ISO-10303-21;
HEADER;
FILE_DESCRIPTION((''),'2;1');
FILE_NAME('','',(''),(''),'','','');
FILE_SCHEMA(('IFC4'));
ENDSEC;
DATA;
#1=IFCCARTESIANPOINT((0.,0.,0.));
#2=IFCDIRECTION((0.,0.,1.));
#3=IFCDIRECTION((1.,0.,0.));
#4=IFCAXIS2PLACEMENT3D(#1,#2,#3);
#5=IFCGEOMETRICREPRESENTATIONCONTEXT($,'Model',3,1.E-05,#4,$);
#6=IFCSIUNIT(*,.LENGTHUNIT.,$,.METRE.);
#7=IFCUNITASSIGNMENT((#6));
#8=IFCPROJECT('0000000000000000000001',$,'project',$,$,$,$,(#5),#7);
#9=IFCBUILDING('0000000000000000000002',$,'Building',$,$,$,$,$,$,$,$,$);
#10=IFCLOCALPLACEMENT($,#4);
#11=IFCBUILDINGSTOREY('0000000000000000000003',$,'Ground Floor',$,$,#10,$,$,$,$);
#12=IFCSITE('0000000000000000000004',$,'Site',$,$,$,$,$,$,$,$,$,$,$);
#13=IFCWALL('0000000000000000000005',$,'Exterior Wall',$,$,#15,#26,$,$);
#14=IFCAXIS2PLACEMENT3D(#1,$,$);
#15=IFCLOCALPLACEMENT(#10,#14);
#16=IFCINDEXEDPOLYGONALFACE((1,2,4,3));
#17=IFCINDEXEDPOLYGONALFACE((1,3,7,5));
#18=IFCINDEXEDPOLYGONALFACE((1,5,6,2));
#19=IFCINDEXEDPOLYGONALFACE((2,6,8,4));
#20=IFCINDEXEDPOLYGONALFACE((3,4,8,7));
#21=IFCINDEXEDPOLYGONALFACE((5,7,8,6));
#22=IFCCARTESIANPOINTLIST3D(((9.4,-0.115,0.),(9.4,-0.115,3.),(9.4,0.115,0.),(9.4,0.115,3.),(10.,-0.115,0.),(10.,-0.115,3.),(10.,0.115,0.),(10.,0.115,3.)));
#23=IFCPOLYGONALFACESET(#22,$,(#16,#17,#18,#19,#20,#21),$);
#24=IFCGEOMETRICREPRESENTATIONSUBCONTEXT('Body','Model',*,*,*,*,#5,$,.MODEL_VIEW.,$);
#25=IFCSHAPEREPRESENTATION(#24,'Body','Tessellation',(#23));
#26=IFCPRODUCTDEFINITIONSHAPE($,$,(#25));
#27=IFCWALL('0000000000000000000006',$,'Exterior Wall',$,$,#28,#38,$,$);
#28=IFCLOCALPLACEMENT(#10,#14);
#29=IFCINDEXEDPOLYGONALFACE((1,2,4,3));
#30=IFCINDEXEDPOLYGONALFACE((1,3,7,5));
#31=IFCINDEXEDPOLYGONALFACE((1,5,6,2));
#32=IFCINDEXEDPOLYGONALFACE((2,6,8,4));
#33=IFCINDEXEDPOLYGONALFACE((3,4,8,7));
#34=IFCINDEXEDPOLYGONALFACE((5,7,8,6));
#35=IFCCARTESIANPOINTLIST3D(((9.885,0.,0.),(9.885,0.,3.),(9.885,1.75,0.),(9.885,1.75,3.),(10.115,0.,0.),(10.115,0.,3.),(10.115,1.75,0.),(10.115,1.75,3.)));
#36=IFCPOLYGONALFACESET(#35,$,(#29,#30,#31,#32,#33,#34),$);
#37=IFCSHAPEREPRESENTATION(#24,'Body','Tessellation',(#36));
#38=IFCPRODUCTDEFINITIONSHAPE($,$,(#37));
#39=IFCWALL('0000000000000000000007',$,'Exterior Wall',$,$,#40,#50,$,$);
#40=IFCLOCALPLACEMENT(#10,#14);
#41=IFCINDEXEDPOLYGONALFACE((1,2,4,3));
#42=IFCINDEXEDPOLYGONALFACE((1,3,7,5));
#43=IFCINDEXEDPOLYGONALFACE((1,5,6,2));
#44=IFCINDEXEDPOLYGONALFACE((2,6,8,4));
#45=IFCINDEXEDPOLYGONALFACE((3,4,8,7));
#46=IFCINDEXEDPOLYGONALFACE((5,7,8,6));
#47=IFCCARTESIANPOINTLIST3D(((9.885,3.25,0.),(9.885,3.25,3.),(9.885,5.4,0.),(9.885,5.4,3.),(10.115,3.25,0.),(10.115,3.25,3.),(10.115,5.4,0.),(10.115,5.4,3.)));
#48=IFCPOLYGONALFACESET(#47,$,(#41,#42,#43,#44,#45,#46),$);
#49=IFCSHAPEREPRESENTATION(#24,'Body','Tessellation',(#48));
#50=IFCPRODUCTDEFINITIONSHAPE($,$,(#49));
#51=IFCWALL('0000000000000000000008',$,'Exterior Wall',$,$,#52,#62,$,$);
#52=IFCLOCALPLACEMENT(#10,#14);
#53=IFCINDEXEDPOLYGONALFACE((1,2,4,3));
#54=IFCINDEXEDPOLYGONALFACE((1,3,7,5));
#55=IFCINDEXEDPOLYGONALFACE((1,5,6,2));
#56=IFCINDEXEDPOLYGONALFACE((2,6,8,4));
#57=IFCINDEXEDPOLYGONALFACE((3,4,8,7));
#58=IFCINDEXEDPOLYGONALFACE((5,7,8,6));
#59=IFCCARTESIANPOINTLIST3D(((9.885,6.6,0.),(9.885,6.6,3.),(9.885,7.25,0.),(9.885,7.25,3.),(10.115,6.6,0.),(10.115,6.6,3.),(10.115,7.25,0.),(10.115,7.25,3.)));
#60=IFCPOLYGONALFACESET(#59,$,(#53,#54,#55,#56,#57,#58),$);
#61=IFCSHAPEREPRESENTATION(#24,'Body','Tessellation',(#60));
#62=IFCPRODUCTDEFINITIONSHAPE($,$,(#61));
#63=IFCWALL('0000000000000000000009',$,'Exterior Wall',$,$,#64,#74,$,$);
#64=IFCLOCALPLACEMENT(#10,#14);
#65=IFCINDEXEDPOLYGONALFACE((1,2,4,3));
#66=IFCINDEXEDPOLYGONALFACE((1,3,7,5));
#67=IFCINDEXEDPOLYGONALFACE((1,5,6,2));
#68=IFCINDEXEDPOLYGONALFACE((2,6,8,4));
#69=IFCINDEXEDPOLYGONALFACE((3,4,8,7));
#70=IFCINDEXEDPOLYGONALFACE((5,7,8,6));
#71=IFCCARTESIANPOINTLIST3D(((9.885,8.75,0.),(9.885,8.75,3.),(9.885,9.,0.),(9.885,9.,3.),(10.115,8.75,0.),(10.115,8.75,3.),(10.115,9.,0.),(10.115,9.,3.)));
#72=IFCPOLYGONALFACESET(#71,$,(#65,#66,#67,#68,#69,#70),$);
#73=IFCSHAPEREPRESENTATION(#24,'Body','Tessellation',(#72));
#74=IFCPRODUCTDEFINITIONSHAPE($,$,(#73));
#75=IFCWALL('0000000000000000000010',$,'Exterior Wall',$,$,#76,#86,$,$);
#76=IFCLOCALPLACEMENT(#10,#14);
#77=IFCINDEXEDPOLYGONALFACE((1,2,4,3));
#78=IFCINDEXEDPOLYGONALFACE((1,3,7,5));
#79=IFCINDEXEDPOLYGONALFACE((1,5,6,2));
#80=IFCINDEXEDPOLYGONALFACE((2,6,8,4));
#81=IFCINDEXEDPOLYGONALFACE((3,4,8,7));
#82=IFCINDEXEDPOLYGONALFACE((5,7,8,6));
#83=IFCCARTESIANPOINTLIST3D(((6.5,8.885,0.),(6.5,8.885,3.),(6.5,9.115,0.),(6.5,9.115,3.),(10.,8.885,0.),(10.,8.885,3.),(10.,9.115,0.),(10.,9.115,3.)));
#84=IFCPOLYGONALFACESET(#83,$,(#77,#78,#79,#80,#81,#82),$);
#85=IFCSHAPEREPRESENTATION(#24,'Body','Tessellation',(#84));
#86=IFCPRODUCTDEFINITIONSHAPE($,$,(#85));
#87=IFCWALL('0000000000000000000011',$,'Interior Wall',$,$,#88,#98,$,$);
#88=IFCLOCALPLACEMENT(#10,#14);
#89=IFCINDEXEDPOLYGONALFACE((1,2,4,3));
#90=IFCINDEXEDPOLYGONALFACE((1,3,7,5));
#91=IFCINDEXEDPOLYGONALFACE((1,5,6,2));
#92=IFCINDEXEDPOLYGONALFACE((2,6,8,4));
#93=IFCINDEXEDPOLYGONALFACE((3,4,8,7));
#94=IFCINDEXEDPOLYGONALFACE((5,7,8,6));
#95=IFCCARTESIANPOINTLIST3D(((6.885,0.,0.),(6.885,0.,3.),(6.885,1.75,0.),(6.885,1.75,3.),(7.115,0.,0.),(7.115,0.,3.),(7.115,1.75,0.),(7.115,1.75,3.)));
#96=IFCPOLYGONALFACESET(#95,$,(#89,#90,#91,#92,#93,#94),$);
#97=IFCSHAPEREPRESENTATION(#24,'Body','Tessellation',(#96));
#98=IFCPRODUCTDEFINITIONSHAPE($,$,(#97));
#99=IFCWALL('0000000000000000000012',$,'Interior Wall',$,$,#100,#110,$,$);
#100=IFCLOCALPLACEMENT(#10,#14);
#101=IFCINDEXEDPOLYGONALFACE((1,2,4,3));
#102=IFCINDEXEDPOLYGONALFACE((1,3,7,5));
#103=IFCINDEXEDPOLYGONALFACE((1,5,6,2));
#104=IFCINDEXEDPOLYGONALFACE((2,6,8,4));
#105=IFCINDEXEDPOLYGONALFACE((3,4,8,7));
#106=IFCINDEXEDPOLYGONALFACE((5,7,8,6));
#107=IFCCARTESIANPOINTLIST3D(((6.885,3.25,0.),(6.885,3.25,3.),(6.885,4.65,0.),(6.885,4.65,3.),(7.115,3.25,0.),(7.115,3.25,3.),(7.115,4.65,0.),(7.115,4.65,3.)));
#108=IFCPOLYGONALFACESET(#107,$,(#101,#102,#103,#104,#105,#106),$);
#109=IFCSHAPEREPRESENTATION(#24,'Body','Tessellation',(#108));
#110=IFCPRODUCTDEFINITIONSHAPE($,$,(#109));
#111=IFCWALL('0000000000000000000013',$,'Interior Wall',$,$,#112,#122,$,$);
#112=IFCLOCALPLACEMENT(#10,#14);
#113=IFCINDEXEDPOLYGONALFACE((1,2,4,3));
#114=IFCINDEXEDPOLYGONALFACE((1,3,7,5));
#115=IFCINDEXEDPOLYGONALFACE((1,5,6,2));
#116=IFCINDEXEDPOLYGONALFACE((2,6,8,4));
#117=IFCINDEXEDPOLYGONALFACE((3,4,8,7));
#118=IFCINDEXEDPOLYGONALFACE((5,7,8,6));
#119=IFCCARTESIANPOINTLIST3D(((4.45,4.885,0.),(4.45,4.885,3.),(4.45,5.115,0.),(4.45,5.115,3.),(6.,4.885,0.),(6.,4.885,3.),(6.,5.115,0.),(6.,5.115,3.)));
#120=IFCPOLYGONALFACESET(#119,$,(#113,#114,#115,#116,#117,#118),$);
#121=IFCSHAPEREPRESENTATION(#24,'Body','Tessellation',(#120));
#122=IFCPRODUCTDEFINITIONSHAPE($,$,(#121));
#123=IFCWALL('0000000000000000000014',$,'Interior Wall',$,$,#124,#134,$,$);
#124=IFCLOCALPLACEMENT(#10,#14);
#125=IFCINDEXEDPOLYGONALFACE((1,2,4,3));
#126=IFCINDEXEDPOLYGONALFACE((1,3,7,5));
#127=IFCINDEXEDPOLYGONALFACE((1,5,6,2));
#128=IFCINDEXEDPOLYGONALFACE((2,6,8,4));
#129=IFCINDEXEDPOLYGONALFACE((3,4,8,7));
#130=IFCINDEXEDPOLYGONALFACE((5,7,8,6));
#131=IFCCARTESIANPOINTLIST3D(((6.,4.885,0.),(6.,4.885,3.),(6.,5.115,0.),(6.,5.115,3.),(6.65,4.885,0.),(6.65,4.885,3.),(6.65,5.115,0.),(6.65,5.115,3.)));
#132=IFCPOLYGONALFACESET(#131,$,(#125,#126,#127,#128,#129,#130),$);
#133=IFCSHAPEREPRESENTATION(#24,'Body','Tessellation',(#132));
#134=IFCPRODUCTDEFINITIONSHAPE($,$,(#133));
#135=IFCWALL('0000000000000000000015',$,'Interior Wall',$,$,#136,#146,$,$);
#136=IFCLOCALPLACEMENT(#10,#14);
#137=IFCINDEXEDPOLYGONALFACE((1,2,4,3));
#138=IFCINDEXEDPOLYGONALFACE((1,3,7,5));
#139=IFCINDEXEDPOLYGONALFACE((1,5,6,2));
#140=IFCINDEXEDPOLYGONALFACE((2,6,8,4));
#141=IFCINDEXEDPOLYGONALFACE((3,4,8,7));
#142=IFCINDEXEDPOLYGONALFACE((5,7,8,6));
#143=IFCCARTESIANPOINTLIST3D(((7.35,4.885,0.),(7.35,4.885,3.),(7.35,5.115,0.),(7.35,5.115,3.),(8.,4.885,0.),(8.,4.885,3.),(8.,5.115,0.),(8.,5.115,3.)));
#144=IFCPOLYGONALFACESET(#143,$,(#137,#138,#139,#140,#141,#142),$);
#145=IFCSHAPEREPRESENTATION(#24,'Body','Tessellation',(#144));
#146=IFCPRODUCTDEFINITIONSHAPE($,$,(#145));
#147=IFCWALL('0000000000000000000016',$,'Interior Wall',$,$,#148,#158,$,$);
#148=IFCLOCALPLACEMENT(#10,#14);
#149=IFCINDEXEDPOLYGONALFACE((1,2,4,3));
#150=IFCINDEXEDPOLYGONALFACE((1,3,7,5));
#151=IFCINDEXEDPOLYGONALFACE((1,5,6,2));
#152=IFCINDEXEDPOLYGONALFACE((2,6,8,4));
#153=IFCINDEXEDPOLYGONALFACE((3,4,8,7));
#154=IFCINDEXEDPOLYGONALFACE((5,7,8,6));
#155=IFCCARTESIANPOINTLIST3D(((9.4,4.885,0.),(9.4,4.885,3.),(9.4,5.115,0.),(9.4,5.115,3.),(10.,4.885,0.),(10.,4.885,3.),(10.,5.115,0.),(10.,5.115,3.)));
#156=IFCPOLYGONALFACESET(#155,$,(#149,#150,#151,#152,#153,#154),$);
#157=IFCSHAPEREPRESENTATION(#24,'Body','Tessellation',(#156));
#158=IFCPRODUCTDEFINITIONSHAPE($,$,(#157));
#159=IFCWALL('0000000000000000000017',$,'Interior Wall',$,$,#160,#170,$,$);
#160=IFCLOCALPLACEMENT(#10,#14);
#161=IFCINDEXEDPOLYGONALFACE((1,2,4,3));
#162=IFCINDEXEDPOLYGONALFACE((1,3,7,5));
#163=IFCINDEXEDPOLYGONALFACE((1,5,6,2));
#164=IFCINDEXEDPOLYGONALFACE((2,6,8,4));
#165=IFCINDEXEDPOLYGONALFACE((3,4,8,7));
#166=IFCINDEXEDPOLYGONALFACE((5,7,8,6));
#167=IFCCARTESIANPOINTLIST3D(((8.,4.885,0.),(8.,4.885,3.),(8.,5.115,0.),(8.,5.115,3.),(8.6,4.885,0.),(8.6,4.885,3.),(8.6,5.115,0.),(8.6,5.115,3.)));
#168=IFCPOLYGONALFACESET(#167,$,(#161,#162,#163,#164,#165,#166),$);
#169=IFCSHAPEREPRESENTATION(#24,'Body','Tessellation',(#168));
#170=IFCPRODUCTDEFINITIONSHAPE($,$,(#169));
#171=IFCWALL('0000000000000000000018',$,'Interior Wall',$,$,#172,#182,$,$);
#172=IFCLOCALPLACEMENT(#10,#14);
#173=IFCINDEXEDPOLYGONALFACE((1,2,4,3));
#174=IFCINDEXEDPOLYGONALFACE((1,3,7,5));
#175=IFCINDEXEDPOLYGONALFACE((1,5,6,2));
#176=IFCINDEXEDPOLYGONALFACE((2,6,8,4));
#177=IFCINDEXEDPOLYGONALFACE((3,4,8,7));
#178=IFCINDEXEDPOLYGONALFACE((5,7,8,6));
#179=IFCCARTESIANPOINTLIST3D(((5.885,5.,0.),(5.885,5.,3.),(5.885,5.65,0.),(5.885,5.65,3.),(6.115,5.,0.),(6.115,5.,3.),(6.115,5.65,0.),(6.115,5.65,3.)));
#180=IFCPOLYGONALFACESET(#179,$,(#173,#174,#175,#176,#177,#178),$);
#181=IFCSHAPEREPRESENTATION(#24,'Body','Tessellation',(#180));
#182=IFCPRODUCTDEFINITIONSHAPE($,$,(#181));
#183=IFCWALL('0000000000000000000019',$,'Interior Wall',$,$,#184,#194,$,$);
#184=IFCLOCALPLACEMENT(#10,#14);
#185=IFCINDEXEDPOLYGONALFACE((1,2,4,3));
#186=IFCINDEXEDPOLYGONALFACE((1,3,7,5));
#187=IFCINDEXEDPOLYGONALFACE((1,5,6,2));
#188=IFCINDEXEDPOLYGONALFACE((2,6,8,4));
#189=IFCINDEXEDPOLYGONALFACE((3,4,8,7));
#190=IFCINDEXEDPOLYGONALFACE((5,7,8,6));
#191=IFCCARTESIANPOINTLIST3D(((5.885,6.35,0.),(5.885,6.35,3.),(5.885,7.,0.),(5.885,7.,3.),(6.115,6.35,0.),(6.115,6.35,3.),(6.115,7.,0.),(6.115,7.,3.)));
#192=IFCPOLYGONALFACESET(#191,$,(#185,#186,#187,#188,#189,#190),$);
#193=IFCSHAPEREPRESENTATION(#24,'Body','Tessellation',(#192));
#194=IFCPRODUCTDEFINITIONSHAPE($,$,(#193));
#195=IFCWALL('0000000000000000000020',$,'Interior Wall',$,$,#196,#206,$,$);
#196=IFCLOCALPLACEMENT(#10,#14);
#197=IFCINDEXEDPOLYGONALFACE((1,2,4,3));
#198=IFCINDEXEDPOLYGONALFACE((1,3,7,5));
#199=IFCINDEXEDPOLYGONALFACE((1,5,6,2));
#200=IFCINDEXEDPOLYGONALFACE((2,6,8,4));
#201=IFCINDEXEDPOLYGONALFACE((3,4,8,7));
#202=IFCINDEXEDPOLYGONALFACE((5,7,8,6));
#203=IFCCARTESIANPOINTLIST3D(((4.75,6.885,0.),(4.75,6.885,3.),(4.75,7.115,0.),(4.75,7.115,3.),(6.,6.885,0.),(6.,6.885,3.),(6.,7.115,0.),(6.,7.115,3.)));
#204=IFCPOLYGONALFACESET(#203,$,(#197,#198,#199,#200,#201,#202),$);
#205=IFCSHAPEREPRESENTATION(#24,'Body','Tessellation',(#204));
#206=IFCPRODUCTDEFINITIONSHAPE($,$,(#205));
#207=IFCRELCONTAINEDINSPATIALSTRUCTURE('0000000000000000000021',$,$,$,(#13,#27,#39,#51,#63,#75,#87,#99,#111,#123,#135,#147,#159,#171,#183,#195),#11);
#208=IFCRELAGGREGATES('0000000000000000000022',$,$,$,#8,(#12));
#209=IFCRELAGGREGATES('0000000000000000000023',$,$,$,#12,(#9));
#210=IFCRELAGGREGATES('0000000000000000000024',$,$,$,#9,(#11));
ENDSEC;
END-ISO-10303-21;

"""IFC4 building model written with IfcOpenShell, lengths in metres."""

from ifc_helpers import new_model, si_unit, frame, origin_with_axes, place, context, subcontext, project, spatial, indexed_curve, outline, extrude, element, save


model = new_model("IFC4")

# Units and contexts
model_context = context("Model", 3, precision=1e-05, world=origin_with_axes())
body_context = subcontext(model_context, "Body", "Model", "MODEL_VIEW")
ifc_project = project(units=[si_unit("LENGTHUNIT", "METRE")], contexts=[model_context])

# Site, building, storey
site = spatial("IfcSite", under=ifc_project, Name="Site")
building = spatial("IfcBuilding", under=site, Name="Building")
storey_placement = place(None, origin_with_axes())
storey = spatial("IfcBuildingStorey", under=building, at=storey_placement, Name="Ground Floor")

# Walls
wall_1_placement = place(storey_placement, frame((9.4, 0.0, 0.0), z_axis=(0.0, 0.0, 1.0), x_axis=(1.0, 0.0, 0.0)))
element("IfcWall", 1, at=wall_1_placement, inside=storey, Name="Exterior Wall", context=body_context, shape_type="SweptSolid", body=[
    extrude(outline(indexed_curve([(0.0, 0.0), (0.0, 0.23), (0.6, 0.23), (0.6, 0.0), (0.0, 0.0)], self_intersect=False)), frame((0.0, -0.115, 0.0), z_axis=(0.0, 0.0, 1.0), x_axis=(1.0, 0.0, 0.0)), (0.0, 0.0, 1.0), 3.0),
])
wall_2_placement = place(storey_placement, frame((10.0, 0.0, 0.0), z_axis=(0.0, 0.0, 1.0), x_axis=(0.0, 1.0, 0.0)))
element("IfcWall", 2, at=wall_2_placement, inside=storey, Name="Exterior Wall", context=body_context, shape_type="SweptSolid", body=[
    extrude(outline(indexed_curve([(0.0, 0.0), (0.0, 0.23), (1.75, 0.23), (1.75, 0.0), (0.0, 0.0)], self_intersect=False)), frame((0.0, -0.115, 0.0), z_axis=(0.0, 0.0, 1.0), x_axis=(1.0, 0.0, 0.0)), (0.0, 0.0, 1.0), 3.0),
])
wall_3_placement = place(storey_placement, frame((10.0, 3.25, 0.0), z_axis=(0.0, 0.0, 1.0), x_axis=(0.0, 1.0, 0.0)))
element("IfcWall", 3, at=wall_3_placement, inside=storey, Name="Exterior Wall", context=body_context, shape_type="SweptSolid", body=[
    extrude(outline(indexed_curve([(0.0, 0.0), (0.0, 0.23), (2.15, 0.23), (2.15, 0.0), (0.0, 0.0)], self_intersect=False)), frame((0.0, -0.115, 0.0), z_axis=(0.0, 0.0, 1.0), x_axis=(1.0, 0.0, 0.0)), (0.0, 0.0, 1.0), 3.0),
])
wall_4_placement = place(storey_placement, frame((10.0, 6.6, 0.0), z_axis=(0.0, 0.0, 1.0), x_axis=(0.0, 1.0, 0.0)))
element("IfcWall", 4, at=wall_4_placement, inside=storey, Name="Exterior Wall", context=body_context, shape_type="SweptSolid", body=[
    extrude(outline(indexed_curve([(0.0, 0.0), (0.0, 0.23), (0.65, 0.23), (0.65, 0.0), (0.0, 0.0)], self_intersect=False)), frame((0.0, -0.115, 0.0), z_axis=(0.0, 0.0, 1.0), x_axis=(1.0, 0.0, 0.0)), (0.0, 0.0, 1.0), 3.0),
])
wall_5_placement = place(storey_placement, frame((10.0, 8.75, 0.0), z_axis=(0.0, 0.0, 1.0), x_axis=(0.0, 1.0, 0.0)))
element("IfcWall", 5, at=wall_5_placement, inside=storey, Name="Exterior Wall", context=body_context, shape_type="SweptSolid", body=[
    extrude(outline(indexed_curve([(0.0, 0.0), (0.0, 0.23), (0.25, 0.23), (0.25, 0.0), (0.0, 0.0)], self_intersect=False)), frame((0.0, -0.115, 0.0), z_axis=(0.0, 0.0, 1.0), x_axis=(1.0, 0.0, 0.0)), (0.0, 0.0, 1.0), 3.0),
])
wall_6_placement = place(storey_placement, frame((10.0, 9.0, 0.0), z_axis=(0.0, 0.0, 1.0), x_axis=(-1.0, 0.0, 0.0)))
element("IfcWall", 6, at=wall_6_placement, inside=storey, Name="Exterior Wall", context=body_context, shape_type="SweptSolid", body=[
    extrude(outline(indexed_curve([(0.0, 0.0), (0.0, 0.23), (3.5, 0.23), (3.5, 0.0), (0.0, 0.0)], self_intersect=False)), frame((0.0, -0.115, 0.0), z_axis=(0.0, 0.0, 1.0), x_axis=(1.0, 0.0, 0.0)), (0.0, 0.0, 1.0), 3.0),
])
wall_7_placement = place(storey_placement, frame((7.0, 0.0, 0.0), z_axis=(0.0, 0.0, 1.0), x_axis=(0.0, 1.0, 0.0)))
element("IfcWall", 7, at=wall_7_placement, inside=storey, Name="Interior Wall", context=body_context, shape_type="SweptSolid", body=[
    extrude(outline(indexed_curve([(0.0, 0.0), (0.0, 0.23), (1.75, 0.23), (1.75, 0.0), (0.0, 0.0)], self_intersect=False)), frame((0.0, -0.115, 0.0), z_axis=(0.0, 0.0, 1.0), x_axis=(1.0, 0.0, 0.0)), (0.0, 0.0, 1.0), 3.0),
])
wall_8_placement = place(storey_placement, frame((7.0, 3.25, 0.0), z_axis=(0.0, 0.0, 1.0), x_axis=(0.0, 1.0, 0.0)))
element("IfcWall", 8, at=wall_8_placement, inside=storey, Name="Interior Wall", context=body_context, shape_type="SweptSolid", body=[
    extrude(outline(indexed_curve([(0.0, 0.0), (0.0, 0.23), (1.4, 0.23), (1.4, 0.0), (0.0, 0.0)], self_intersect=False)), frame((0.0, -0.115, 0.0), z_axis=(0.0, 0.0, 1.0), x_axis=(1.0, 0.0, 0.0)), (0.0, 0.0, 1.0), 3.0),
])
wall_9_placement = place(storey_placement, frame((6.0, 5.0, 0.0), z_axis=(0.0, 0.0, 1.0), x_axis=(-1.0, 0.0, 0.0)))
element("IfcWall", 9, at=wall_9_placement, inside=storey, Name="Interior Wall", context=body_context, shape_type="SweptSolid", body=[
    extrude(outline(indexed_curve([(0.0, 0.0), (0.0, 0.23), (1.55, 0.23), (1.55, 0.0), (0.0, 0.0)], self_intersect=False)), frame((0.0, -0.115, 0.0), z_axis=(0.0, 0.0, 1.0), x_axis=(1.0, 0.0, 0.0)), (0.0, 0.0, 1.0), 3.0),
])
for number, where, z_axis, x_axis, name in (
    (10, (6.65, 5.0, 0.0), (0.0, 0.0, 1.0), (-1.0, 0.0, 0.0), "Interior Wall"),
    (11, (8.0, 5.0, 0.0), (0.0, 0.0, 1.0), (-1.0, 0.0, 0.0), "Interior Wall"),
):
    element("IfcWall", number, at=place(storey_placement, frame(where, z_axis=z_axis, x_axis=x_axis)), inside=storey, Name=name, context=body_context, shape_type="SweptSolid", body=[
        extrude(outline(indexed_curve([(0.0, 0.0), (0.0, 0.23), (0.65, 0.23), (0.65, 0.0), (0.0, 0.0)], self_intersect=False)), frame((0.0, -0.115, 0.0), z_axis=(0.0, 0.0, 1.0), x_axis=(1.0, 0.0, 0.0)), (0.0, 0.0, 1.0), 3.0),
    ])
for number, where, z_axis, x_axis, name in (
    (12, (10.0, 5.0, 0.0), (0.0, 0.0, 1.0), (-1.0, 0.0, 0.0), "Interior Wall"),
    (13, (8.6, 5.0, 0.0), (0.0, 0.0, 1.0), (-1.0, 0.0, 0.0), "Interior Wall"),
):
    element("IfcWall", number, at=place(storey_placement, frame(where, z_axis=z_axis, x_axis=x_axis)), inside=storey, Name=name, context=body_context, shape_type="SweptSolid", body=[
        extrude(outline(indexed_curve([(0.0, 0.0), (0.0, 0.23), (0.6, 0.23), (0.6, 0.0), (0.0, 0.0)], self_intersect=False)), frame((0.0, -0.115, 0.0), z_axis=(0.0, 0.0, 1.0), x_axis=(1.0, 0.0, 0.0)), (0.0, 0.0, 1.0), 3.0),
    ])
for number, where, z_axis, x_axis, name in (
    (14, (6.0, 5.0, 0.0), (0.0, 0.0, 1.0), (0.0, 1.0, 0.0), "Interior Wall"),
    (15, (6.0, 6.35, 0.0), (0.0, 0.0, 1.0), (0.0, 1.0, 0.0), "Interior Wall"),
):
    element("IfcWall", number, at=place(storey_placement, frame(where, z_axis=z_axis, x_axis=x_axis)), inside=storey, Name=name, context=body_context, shape_type="SweptSolid", body=[
        extrude(outline(indexed_curve([(0.0, 0.0), (0.0, 0.23), (0.65, 0.23), (0.65, 0.0), (0.0, 0.0)], self_intersect=False)), frame((0.0, -0.115, 0.0), z_axis=(0.0, 0.0, 1.0), x_axis=(1.0, 0.0, 0.0)), (0.0, 0.0, 1.0), 3.0),
    ])
wall_10_placement = place(storey_placement, frame((6.0, 7.0, 0.0), z_axis=(0.0, 0.0, 1.0), x_axis=(-1.0, 0.0, 0.0)))
element("IfcWall", 16, at=wall_10_placement, inside=storey, Name="Interior Wall", context=body_context, shape_type="SweptSolid", body=[
    extrude(outline(indexed_curve([(0.0, 0.0), (0.0, 0.23), (1.25, 0.23), (1.25, 0.0), (0.0, 0.0)], self_intersect=False)), frame((0.0, -0.115, 0.0), z_axis=(0.0, 0.0, 1.0), x_axis=(1.0, 0.0, 0.0)), (0.0, 0.0, 1.0), 3.0),
])

save(model, "model.ifc")
